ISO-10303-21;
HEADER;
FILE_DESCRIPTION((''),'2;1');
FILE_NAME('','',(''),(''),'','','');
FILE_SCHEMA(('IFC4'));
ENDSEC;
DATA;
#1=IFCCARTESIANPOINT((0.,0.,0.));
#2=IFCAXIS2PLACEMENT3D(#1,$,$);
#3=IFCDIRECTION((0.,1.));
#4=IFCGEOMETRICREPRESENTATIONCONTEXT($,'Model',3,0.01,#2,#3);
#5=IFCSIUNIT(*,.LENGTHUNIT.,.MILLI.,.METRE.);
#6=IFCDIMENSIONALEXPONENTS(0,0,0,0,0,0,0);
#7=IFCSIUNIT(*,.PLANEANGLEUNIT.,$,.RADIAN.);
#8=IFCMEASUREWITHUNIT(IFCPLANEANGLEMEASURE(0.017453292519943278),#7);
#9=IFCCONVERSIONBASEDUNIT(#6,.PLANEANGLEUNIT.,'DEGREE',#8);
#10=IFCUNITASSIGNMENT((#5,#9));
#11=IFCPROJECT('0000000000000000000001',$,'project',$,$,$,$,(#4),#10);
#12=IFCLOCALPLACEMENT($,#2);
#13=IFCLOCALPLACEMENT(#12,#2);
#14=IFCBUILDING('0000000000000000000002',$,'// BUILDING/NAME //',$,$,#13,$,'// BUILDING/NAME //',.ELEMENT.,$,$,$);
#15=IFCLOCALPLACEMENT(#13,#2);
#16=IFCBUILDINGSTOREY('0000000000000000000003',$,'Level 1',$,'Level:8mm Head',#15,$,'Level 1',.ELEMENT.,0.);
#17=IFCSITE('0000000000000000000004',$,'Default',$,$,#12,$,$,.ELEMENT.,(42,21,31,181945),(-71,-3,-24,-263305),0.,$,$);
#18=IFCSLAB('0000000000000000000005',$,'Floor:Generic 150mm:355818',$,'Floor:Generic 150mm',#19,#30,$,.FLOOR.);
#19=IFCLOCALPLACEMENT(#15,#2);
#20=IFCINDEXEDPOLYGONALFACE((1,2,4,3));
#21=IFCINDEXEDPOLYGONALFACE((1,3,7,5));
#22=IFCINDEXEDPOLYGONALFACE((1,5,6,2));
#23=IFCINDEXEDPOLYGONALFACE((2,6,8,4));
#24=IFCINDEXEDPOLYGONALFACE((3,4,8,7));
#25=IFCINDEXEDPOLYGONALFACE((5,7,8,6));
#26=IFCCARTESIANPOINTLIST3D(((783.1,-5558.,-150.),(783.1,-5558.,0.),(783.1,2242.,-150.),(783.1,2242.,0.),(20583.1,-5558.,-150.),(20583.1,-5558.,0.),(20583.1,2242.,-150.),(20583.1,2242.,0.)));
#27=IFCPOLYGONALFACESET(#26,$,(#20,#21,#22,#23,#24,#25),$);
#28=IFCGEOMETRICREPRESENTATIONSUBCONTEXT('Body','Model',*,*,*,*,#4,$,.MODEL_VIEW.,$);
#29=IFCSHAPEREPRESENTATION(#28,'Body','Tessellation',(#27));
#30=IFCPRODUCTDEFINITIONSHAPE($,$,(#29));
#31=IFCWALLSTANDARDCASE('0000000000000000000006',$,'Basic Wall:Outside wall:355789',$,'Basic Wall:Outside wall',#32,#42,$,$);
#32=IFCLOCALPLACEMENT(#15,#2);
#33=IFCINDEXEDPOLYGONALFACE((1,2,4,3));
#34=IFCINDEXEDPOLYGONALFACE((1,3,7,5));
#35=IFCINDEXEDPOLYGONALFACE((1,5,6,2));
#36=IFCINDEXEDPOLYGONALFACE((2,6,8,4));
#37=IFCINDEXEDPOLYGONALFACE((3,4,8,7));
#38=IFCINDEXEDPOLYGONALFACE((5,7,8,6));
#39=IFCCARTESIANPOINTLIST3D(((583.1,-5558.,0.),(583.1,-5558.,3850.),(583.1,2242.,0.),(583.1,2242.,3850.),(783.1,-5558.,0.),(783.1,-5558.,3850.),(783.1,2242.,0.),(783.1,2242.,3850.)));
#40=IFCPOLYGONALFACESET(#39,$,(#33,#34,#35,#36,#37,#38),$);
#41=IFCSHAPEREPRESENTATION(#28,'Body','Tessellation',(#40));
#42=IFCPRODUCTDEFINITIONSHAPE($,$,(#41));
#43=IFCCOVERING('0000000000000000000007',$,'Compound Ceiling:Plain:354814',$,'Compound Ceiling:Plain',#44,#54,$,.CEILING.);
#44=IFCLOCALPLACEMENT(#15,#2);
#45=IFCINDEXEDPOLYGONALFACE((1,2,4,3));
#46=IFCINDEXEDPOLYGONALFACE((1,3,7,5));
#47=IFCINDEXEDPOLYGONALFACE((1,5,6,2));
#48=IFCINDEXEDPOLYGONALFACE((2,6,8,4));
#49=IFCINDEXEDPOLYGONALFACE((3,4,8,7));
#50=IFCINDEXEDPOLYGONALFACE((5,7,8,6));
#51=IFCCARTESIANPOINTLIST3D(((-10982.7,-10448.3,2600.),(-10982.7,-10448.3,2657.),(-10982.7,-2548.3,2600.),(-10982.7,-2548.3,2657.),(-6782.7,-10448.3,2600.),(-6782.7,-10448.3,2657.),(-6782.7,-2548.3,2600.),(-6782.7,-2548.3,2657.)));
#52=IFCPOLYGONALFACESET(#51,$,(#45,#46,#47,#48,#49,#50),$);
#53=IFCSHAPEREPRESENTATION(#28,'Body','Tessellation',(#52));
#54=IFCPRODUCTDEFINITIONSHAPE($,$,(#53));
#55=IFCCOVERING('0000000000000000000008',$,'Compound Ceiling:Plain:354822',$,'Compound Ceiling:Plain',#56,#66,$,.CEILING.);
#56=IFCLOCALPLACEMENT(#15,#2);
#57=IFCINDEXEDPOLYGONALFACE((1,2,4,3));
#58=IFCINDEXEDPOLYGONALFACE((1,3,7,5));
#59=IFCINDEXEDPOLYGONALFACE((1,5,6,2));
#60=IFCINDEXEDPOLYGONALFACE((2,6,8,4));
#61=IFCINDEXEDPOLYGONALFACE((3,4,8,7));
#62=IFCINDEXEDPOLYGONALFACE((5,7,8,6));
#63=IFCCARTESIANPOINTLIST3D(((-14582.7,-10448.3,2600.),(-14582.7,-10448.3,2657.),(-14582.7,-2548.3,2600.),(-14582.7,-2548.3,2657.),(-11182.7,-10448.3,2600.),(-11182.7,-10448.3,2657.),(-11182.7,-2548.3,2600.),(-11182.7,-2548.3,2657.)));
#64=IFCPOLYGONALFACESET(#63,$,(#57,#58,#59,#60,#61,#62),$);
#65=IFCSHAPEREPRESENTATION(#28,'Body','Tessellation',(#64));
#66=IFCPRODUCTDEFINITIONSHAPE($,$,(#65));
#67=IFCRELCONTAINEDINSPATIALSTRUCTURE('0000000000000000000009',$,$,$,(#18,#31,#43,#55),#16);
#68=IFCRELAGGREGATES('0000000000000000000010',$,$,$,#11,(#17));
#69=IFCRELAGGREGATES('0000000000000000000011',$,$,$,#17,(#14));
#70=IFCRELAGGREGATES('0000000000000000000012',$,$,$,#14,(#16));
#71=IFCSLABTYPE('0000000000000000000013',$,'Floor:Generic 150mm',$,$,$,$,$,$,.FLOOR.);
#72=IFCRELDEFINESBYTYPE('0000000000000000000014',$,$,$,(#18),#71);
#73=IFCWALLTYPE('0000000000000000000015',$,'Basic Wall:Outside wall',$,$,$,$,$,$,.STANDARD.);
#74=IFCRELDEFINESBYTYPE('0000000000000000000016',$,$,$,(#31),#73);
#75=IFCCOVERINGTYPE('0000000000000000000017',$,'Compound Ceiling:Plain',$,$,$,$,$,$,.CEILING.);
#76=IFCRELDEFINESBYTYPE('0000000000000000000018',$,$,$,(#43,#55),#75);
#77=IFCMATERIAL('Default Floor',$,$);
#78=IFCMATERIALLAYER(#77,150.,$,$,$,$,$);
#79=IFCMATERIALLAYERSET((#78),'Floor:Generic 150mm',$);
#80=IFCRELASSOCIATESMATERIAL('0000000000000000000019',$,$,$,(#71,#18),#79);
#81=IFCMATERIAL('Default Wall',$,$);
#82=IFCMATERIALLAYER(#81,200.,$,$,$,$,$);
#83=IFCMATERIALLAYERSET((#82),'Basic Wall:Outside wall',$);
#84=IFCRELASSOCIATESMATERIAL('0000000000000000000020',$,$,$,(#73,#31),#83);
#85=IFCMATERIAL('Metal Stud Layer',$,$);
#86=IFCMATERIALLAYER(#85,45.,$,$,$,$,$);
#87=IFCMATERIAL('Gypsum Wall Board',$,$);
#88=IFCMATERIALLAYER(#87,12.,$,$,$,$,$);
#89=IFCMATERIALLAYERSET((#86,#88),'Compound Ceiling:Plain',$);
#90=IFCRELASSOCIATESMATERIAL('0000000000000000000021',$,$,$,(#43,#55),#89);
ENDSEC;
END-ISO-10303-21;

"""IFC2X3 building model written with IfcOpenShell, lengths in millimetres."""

from ifc_helpers import new_model, entity, si_unit, converted_unit, direction, frame, frame_2d, origin, place, context, subcontext, project, spatial, rectangle, extrude, material, layer, layer_set, layer_usage, type_object, element, save


model = new_model("IFC2X3")

# Units and contexts
model_context = context("Model", 3, precision=0.01, world=origin(), true_north=direction((0.0, 1.0)))
body_context = subcontext(model_context, "Body", "Model", "MODEL_VIEW")
ifc_project = project(units=[si_unit("LENGTHUNIT", "METRE", prefix="MILLI"), converted_unit("PLANEANGLEUNIT", "DEGREE", entity("IfcPlaneAngleMeasure", 0.017453292519943278), si_unit("PLANEANGLEUNIT", "RADIAN"), dimensions=[0, 0, 0, 0, 0, 0, 0])], contexts=[model_context])

# Site, building, storey
site_placement = place(None, origin())
site = spatial("IfcSite", under=ifc_project, at=site_placement, Name="Default", CompositionType="ELEMENT", RefLatitude=(42, 21, 31, 181945), RefLongitude=(-71, -3, -24, -263305), RefElevation=0.0)
building_placement = place(site_placement, origin())
building = spatial("IfcBuilding", under=site, at=building_placement, Name="// BUILDING/NAME //", LongName="// BUILDING/NAME //", CompositionType="ELEMENT")
storey_placement = place(building_placement, origin())
storey = spatial("IfcBuildingStorey", under=building, at=storey_placement, Name="Level 1", ObjectType="Level:8mm Head", LongName="Level 1", CompositionType="ELEMENT", Elevation=0.0)

# Slab
ifc_material_1 = material(Name="Default Floor")
ifc_layer_1 = layer(ifc_material_1, 150.0)
ifc_layer_set_1 = layer_set([ifc_layer_1], Name="Floor:Generic 150mm")
ifc_layer_usage_1 = layer_usage(ifc_layer_set_1, "AXIS3", "POSITIVE", 0.0)
slab_type = type_object("IfcSlabType", Name="Floor:Generic 150mm", PredefinedType="FLOOR", material=ifc_layer_set_1)
slab_placement = place(storey_placement, origin())
element("IfcSlab", 1, at=slab_placement, inside=storey, type_object=slab_type, material=ifc_layer_usage_1, Name="Floor:Generic 150mm:355818", ObjectType="Floor:Generic 150mm", PredefinedType="FLOOR", context=body_context, shape_type="SweptSolid", body=[
    extrude(rectangle(XDim=7800.0, YDim=19800.0, at=frame_2d((0.0, 0.0), x_axis=(1.0, 0.0))), frame((10683.1, -1658.0, 0.0), z_axis=(0.0, 0.0, -1.0), x_axis=(0.0, 1.0, 0.0)), (0.0, 0.0, 1.0), 150.0),
])

# Wall
ifc_material_2 = material(Name="Default Wall")
ifc_layer_2 = layer(ifc_material_2, 200.0)
ifc_layer_set_2 = layer_set([ifc_layer_2], Name="Basic Wall:Outside wall")
ifc_layer_usage_2 = layer_usage(ifc_layer_set_2, "AXIS2", "NEGATIVE", 100.0)
wall_type = type_object("IfcWallType", Name="Basic Wall:Outside wall", PredefinedType="STANDARD", material=ifc_layer_set_2)
wall_placement = place(storey_placement, frame((683.1, 2242.0, 0.0), z_axis=(0.0, 0.0, 1.0), x_axis=(0.0, -1.0, 0.0)))
element("IfcWallStandardCase", 2, at=wall_placement, inside=storey, type_object=wall_type, material=ifc_layer_usage_2, Name="Basic Wall:Outside wall:355789", ObjectType="Basic Wall:Outside wall", context=body_context, shape_type="SweptSolid", body=[
    extrude(rectangle(XDim=7800.0, YDim=200.0, at=frame_2d((3900.0, 0.0), x_axis=(-1.0, 0.0))), origin(), (0.0, 0.0, 1.0), 3850.0),
])

# Coverings
ifc_material_3 = material(Name="Metal Stud Layer")
ifc_layer_3 = layer(ifc_material_3, 45.0)
ifc_material_4 = material(Name="Gypsum Wall Board")
ifc_layer_4 = layer(ifc_material_4, 12.0)
ifc_layer_set_3 = layer_set([ifc_layer_3, ifc_layer_4], Name="Compound Ceiling:Plain")
ifc_layer_usage_3 = layer_usage(ifc_layer_set_3, "AXIS3", "NEGATIVE", 57.0)
covering_type = type_object("IfcCoveringType", Name="Compound Ceiling:Plain", PredefinedType="CEILING")
covering_1_placement = place(storey_placement, origin())
element("IfcCovering", 3, at=covering_1_placement, inside=storey, type_object=covering_type, material=ifc_layer_usage_3, Name="Compound Ceiling:Plain:354814", ObjectType="Compound Ceiling:Plain", PredefinedType="CEILING", context=body_context, shape_type="SweptSolid", body=[
    extrude(rectangle(XDim=4200.0, YDim=7900.0, at=frame_2d((0.0, 0.0), x_axis=(1.0, 0.0))), frame((-8882.7, -6498.3, 2600.0), z_axis=(0.0, 0.0, 1.0), x_axis=(-1.0, 0.0, 0.0)), (0.0, 0.0, 1.0), 57.0),
])
covering_2_placement = place(storey_placement, origin())
element("IfcCovering", 4, at=covering_2_placement, inside=storey, type_object=covering_type, material=ifc_layer_usage_3, Name="Compound Ceiling:Plain:354822", ObjectType="Compound Ceiling:Plain", PredefinedType="CEILING", context=body_context, shape_type="SweptSolid", body=[
    extrude(rectangle(XDim=7900.0, YDim=3400.0, at=frame_2d((0.0, 0.0), x_axis=(1.0, 0.0))), frame((-12882.7, -6498.3, 2600.0), z_axis=(0.0, 0.0, 1.0), x_axis=(0.0, 1.0, 0.0)), (0.0, 0.0, 1.0), 57.0),
])

save(model, "model.ifc")
